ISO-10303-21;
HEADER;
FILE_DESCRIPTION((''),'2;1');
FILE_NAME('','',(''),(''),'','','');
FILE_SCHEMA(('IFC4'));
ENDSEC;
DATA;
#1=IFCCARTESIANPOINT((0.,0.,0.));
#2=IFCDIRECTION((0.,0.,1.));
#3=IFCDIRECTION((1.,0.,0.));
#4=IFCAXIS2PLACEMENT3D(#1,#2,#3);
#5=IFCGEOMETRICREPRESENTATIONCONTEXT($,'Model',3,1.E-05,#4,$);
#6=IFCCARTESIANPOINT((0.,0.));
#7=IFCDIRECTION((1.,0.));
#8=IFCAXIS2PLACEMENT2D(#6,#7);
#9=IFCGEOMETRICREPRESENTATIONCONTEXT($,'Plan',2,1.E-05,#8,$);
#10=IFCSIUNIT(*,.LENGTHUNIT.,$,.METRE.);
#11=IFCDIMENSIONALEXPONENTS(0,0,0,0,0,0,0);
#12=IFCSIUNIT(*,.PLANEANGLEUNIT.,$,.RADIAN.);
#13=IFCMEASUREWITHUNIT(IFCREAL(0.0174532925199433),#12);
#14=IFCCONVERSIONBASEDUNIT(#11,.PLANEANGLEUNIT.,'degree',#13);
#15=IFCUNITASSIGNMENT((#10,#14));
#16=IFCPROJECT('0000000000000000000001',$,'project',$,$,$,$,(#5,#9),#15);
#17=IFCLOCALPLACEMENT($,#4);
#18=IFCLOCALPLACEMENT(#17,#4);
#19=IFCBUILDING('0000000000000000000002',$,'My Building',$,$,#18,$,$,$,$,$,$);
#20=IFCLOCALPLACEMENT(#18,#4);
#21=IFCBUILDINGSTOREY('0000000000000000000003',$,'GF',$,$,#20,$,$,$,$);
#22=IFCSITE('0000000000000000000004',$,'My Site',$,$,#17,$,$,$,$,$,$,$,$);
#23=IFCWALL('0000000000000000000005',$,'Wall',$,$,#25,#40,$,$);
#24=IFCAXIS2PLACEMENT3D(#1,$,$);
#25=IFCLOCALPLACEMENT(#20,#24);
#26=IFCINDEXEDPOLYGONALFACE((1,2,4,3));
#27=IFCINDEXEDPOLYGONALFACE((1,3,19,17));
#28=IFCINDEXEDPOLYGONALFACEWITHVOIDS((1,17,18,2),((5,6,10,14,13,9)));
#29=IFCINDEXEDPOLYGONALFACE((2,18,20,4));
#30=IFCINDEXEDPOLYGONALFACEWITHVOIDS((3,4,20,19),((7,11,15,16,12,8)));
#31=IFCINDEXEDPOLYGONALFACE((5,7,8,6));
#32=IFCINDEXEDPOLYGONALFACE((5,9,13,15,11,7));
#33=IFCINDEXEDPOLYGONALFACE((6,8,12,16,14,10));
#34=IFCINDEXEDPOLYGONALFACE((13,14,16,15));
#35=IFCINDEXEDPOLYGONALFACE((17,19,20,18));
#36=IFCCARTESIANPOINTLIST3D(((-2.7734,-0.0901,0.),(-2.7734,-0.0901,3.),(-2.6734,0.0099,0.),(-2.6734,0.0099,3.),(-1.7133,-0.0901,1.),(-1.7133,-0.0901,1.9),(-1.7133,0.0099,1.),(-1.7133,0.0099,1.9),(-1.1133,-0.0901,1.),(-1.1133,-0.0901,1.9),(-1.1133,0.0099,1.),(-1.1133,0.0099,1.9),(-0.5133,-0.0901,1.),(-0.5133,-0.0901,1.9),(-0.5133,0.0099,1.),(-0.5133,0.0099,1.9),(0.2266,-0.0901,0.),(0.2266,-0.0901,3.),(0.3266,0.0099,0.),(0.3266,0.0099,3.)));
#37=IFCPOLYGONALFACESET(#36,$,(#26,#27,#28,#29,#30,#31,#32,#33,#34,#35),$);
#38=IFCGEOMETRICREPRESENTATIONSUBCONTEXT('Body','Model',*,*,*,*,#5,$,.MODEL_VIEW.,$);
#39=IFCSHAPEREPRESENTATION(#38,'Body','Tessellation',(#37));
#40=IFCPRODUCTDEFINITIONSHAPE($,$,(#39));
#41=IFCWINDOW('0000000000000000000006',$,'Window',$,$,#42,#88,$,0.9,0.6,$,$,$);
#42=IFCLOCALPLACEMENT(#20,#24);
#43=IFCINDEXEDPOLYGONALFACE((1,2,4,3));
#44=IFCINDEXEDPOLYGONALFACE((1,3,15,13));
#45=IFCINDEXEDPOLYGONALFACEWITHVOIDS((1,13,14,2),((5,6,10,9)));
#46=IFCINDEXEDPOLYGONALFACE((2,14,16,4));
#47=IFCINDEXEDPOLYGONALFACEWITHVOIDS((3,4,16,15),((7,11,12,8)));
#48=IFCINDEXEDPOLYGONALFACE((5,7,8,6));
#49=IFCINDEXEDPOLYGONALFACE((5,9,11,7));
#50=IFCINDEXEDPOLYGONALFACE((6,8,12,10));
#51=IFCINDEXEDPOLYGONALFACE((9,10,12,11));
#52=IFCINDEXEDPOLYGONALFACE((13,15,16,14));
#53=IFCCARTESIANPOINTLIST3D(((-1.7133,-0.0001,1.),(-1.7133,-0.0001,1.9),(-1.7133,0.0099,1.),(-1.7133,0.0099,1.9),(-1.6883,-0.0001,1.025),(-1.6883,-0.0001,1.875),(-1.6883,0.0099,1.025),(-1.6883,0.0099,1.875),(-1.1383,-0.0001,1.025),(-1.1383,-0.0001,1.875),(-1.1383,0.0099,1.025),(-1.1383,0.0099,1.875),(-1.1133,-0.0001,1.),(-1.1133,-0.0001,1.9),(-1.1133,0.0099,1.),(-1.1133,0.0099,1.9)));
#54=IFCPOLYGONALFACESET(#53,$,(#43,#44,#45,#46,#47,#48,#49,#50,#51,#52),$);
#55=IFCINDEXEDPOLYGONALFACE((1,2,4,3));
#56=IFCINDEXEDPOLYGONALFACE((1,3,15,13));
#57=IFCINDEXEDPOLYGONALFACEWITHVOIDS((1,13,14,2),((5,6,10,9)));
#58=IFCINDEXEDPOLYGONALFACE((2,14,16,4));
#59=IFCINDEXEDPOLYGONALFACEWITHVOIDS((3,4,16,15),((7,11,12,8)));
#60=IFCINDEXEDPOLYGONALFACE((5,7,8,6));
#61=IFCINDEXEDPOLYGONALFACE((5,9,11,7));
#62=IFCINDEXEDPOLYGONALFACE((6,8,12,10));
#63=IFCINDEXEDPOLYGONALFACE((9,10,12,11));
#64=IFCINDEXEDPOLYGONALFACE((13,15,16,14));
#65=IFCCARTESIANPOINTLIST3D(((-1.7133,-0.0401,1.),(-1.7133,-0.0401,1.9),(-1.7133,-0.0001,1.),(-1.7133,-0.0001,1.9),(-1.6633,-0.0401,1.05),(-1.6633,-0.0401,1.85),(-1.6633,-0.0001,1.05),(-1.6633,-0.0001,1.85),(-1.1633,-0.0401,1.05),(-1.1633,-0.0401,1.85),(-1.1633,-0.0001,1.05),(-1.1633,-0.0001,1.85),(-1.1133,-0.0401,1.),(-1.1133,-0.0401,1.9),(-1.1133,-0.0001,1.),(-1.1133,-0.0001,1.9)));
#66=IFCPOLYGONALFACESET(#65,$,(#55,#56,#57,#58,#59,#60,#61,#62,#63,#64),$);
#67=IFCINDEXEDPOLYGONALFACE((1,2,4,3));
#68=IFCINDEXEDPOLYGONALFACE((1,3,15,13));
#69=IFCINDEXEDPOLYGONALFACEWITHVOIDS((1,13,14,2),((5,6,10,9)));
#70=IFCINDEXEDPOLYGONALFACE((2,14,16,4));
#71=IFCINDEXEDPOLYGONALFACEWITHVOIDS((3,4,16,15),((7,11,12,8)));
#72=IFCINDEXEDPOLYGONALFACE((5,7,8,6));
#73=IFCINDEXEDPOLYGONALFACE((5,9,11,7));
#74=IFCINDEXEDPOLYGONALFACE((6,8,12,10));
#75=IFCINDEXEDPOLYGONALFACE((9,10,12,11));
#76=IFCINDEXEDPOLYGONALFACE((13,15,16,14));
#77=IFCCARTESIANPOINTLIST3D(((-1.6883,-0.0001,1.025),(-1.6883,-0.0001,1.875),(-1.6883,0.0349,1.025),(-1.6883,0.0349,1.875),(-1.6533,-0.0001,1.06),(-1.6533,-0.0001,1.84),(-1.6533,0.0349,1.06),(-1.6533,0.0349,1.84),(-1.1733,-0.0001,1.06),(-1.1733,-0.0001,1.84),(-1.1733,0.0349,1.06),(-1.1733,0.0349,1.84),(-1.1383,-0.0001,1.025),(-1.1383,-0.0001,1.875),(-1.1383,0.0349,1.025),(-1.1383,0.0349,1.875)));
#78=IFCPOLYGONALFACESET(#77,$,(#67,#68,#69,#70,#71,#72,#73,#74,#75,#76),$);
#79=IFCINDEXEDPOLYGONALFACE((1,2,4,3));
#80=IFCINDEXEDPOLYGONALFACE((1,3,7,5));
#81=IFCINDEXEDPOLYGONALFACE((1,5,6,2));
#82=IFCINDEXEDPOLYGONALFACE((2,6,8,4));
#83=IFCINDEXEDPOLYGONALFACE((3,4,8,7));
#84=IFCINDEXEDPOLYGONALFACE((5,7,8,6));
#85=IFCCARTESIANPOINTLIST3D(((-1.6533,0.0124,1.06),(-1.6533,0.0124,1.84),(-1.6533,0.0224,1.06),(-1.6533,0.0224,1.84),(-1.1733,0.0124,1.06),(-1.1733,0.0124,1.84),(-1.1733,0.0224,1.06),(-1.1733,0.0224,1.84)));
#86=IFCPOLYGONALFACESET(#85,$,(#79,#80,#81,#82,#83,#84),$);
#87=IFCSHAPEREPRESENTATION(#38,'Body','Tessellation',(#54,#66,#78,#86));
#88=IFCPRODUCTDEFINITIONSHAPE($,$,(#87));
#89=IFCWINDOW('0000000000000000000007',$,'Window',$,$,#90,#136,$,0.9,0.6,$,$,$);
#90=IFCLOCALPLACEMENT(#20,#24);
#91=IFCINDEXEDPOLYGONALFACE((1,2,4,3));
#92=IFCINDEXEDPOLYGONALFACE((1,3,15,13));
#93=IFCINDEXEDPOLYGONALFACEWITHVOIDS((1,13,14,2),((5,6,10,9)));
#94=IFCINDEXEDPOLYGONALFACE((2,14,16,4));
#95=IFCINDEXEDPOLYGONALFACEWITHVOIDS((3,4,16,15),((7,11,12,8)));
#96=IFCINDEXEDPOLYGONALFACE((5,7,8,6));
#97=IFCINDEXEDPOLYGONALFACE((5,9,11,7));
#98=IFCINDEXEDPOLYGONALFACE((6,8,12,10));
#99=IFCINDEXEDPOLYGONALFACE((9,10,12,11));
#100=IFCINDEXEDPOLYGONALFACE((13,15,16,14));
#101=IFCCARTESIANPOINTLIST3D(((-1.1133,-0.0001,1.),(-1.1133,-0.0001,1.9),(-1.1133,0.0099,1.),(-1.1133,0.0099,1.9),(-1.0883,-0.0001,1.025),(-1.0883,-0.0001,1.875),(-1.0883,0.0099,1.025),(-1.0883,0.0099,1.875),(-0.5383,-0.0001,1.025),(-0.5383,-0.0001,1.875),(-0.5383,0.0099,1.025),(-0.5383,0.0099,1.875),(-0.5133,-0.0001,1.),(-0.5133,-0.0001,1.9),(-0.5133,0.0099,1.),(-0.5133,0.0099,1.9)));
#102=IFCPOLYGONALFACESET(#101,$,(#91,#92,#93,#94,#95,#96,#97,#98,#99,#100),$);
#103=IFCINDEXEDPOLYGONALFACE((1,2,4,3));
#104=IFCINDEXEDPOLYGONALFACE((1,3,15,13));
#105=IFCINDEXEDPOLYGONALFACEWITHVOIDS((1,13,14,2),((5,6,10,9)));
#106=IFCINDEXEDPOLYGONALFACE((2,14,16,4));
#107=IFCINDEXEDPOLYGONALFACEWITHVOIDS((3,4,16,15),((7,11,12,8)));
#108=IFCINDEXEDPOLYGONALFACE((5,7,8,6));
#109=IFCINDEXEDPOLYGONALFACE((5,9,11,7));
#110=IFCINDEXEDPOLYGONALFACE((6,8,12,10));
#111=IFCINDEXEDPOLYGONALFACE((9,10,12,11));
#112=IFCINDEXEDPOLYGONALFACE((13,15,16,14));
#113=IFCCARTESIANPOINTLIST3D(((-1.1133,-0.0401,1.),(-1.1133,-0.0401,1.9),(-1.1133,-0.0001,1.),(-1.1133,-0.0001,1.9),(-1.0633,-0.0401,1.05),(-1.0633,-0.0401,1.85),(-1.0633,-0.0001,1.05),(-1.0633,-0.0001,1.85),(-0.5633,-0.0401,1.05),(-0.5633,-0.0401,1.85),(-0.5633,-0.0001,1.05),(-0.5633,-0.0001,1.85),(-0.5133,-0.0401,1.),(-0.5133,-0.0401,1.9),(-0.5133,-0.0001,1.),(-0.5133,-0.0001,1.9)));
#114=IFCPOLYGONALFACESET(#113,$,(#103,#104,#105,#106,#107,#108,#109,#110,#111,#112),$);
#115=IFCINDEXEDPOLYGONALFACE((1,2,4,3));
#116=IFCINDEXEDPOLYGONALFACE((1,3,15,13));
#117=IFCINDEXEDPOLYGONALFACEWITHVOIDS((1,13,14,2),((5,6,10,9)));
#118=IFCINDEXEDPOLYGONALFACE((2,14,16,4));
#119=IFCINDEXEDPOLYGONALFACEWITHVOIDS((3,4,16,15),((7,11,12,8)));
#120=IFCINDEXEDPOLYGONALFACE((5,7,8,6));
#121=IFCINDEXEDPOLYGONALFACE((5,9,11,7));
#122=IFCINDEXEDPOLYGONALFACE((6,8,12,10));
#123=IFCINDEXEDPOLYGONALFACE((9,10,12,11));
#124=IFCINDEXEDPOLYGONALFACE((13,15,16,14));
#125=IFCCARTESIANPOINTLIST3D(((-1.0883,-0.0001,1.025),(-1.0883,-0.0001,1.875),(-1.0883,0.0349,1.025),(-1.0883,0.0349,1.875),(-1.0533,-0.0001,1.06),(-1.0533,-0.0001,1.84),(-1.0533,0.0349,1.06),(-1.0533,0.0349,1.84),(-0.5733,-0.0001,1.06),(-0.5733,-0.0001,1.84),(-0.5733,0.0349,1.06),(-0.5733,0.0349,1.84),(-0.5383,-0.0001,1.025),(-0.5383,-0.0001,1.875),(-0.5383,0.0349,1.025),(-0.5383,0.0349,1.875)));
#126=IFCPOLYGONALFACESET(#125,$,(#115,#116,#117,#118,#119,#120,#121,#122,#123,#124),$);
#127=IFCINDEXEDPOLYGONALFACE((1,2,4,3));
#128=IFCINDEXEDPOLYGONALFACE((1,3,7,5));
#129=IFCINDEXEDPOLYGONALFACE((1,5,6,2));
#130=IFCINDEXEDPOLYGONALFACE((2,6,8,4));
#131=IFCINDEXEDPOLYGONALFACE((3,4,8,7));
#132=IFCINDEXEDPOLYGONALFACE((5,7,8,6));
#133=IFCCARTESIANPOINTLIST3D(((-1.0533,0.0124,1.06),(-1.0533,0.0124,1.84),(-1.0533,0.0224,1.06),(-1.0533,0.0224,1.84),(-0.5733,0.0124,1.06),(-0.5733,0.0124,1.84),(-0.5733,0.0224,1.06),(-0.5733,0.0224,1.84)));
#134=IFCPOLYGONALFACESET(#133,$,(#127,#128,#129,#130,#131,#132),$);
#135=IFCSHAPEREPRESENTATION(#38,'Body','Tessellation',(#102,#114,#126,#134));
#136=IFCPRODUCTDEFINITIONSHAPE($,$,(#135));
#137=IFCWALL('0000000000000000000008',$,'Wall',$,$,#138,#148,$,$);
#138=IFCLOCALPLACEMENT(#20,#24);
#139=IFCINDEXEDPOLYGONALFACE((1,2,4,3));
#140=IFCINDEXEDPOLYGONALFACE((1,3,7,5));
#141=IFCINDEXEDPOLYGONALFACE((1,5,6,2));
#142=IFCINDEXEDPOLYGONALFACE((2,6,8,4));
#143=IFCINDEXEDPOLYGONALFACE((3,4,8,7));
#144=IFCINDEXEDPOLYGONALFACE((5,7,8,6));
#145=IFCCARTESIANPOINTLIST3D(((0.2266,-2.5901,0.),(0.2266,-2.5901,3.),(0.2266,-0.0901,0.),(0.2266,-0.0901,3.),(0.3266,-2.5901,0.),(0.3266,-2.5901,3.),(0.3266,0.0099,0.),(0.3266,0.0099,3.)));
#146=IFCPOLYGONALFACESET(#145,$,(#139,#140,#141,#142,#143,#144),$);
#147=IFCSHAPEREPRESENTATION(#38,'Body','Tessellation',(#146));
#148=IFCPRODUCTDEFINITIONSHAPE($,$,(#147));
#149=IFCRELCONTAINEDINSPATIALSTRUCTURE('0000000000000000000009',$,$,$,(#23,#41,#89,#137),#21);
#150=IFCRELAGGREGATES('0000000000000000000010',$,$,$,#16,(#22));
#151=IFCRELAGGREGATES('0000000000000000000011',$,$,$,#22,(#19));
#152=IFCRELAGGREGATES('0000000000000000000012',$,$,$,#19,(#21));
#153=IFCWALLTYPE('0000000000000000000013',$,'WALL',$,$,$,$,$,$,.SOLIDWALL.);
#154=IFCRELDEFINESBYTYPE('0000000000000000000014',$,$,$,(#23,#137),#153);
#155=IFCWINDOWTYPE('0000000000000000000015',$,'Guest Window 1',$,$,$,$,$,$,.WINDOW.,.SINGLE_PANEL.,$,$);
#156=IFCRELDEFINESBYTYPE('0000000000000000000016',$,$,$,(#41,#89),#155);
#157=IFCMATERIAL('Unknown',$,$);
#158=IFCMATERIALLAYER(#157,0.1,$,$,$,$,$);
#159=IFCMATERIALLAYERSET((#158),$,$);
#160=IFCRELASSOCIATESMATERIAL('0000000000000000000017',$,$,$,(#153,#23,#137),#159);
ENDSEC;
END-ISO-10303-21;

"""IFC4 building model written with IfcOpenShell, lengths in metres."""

from ifc_helpers import new_model, entity, si_unit, converted_unit, frame, origin_with_axes, origin_2d_with_axis, place, context, subcontext, project, spatial, line, indexed_curve, outline, extrude, shape, source, transform, mapped, material, layer, layer_set, layer_usage, type_object, type_shapes, element, fill, save


model = new_model("IFC4")

# Units and contexts
model_context = context("Model", 3, precision=1e-05, world=origin_with_axes())
plan_context = context("Plan", 2, precision=1e-05, world=origin_2d_with_axis())
body_context_1 = subcontext(model_context, "Body", "Model", "MODEL_VIEW")
body_context_2 = subcontext(plan_context, "Body", "Plan", "PLAN_VIEW")
ifc_project = project(units=[si_unit("LENGTHUNIT", "METRE"), converted_unit("PLANEANGLEUNIT", "degree", entity("IfcReal", 0.0174532925199433), si_unit("PLANEANGLEUNIT", "RADIAN"), dimensions=[0, 0, 0, 0, 0, 0, 0])], contexts=[model_context, plan_context])

# Site, building, storey
site_placement = place(None, origin_with_axes())
site = spatial("IfcSite", under=ifc_project, at=site_placement, Name="My Site")
building_placement = place(site_placement, origin_with_axes())
building = spatial("IfcBuilding", under=site, at=building_placement, Name="My Building")
storey_placement = place(building_placement, origin_with_axes())
storey = spatial("IfcBuildingStorey", under=building, at=storey_placement, Name="GF")

# Shared definitions
ifc_material_1 = material(Name="Unknown")

# Shared definitions
ifc_layer_1 = layer(ifc_material_1, 0.1)
ifc_layer_set_1 = layer_set([ifc_layer_1])
wall_type = type_object("IfcWallType", Name="WALL", PredefinedType="SOLIDWALL", material=ifc_layer_set_1)

# Wall, openings, windows
ifc_layer_usage_1 = layer_usage(ifc_layer_set_1, "AXIS2", "POSITIVE", 0.0)
wall_1_placement = place(storey_placement, frame((-2.7734, -0.0901, 0.0), z_axis=(0.0, 0.0, 1.0), x_axis=(1.0, 0.0, 0.0)))
wall_1 = element("IfcWall", 1, at=wall_1_placement, inside=storey, type_object=wall_type, material=ifc_layer_usage_1, Name="Wall", context=body_context_1, shape_type="SweptSolid", body=[
    extrude(outline(indexed_curve([(0.0, 0.0), (0.1, 0.1), (3.1, 0.1), (3.0, 0.0)], segments=[line(1, 2, 3, 4, 1)])), origin_with_axes(), (0.0, 0.0, 1.0), 3.0),
])
shared_shape_1 = source(origin_with_axes(), body_context_1, "Body", "SweptSolid", [
    extrude(outline(indexed_curve([(0.0, 0.0), (0.6, 0.0), (0.6, 0.9), (0.0, 0.9)], segments=[line(1, 2, 3, 4, 1)])), frame((0.0, -0.6, 0.0), z_axis=(0.0, -1.0, 0.0), x_axis=(1.0, 0.0, 0.0)), (0.0, 0.0, -1.0), 1.2),
])
opening_1_placement = place(wall_1_placement, frame((1.0601, 0.0, 1.0), z_axis=(0.0, 0.0, 1.0), x_axis=(1.0, 0.0, 0.0)))
opening_1 = element("IfcOpeningElement", 2, at=opening_1_placement, cuts=wall_1, PredefinedType="OPENING", context=body_context_1, shape_type="MappedRepresentation", body=[
    mapped(shared_shape_1, transform((0.0, 0.0, 0.0), x_axis=(1.0, 0.0, 0.0), y_axis=(0.0, 1.0, 0.0), z_axis=(0.0, 0.0, 1.0), scale=1.0)),
])
opening_2_placement = place(wall_1_placement, frame((1.6601, 0.0, 1.0), z_axis=(0.0, 0.0, 1.0), x_axis=(1.0, 0.0, 0.0)))
opening_2 = element("IfcOpeningElement", 3, at=opening_2_placement, cuts=wall_1, PredefinedType="OPENING", context=body_context_1, shape_type="MappedRepresentation", body=[
    mapped(shared_shape_1, transform((0.0, 0.0, 0.0), x_axis=(1.0, 0.0, 0.0), y_axis=(0.0, 1.0, 0.0), z_axis=(0.0, 0.0, 1.0), scale=1.0)),
])
window_type_1 = type_object("IfcWindowType", Name="Guest Window 1", PartitioningType="SINGLE_PANEL", PredefinedType="WINDOW")
shared_shape_2 = source(origin_with_axes(), body_context_1, "Body", "SweptSolid", [
    extrude(outline(indexed_curve([(0.0, 0.0), (0.6, 0.0), (0.6, 0.9), (0.0, 0.9)], segments=[line(1, 2, 3, 4, 1)]), holes=[indexed_curve([(0.025, 0.025), (0.575, 0.025), (0.575, 0.875), (0.025, 0.875)], segments=[line(1, 2, 3, 4, 1)])]), frame((0.0, 0.09, 0.0), z_axis=(0.0, -1.0, 0.0), x_axis=(1.0, 0.0, 0.0)), (0.0, 0.0, -1.0), 0.01),
    extrude(outline(indexed_curve([(0.0, 0.0), (0.6, 0.0), (0.6, 0.9), (0.0, 0.9)], segments=[line(1, 2, 3, 4, 1)]), holes=[indexed_curve([(0.05, 0.05), (0.55, 0.05), (0.55, 0.85), (0.05, 0.85)], segments=[line(1, 2, 3, 4, 1)])]), frame((0.0, 0.05, 0.0), z_axis=(0.0, -1.0, 0.0), x_axis=(1.0, 0.0, 0.0)), (0.0, 0.0, -1.0), 0.04),
    extrude(outline(indexed_curve([(0.0, 0.0), (0.55, 0.0), (0.55, 0.85), (0.0, 0.85)], segments=[line(1, 2, 3, 4, 1)]), holes=[indexed_curve([(0.035, 0.035), (0.515, 0.035), (0.515, 0.815), (0.035, 0.815)], segments=[line(1, 2, 3, 4, 1)])]), frame((0.025, 0.09, 0.025), z_axis=(0.0, -1.0, 0.0), x_axis=(1.0, 0.0, 0.0)), (0.0, 0.0, -1.0), 0.035),
    extrude(outline(indexed_curve([(0.035, 0.035), (0.515, 0.035), (0.515, 0.815), (0.035, 0.815)], segments=[line(1, 2, 3, 4, 1)])), frame((0.025, 0.1025, 0.025), z_axis=(0.0, -1.0, 0.0), x_axis=(1.0, 0.0, 0.0)), (0.0, 0.0, -1.0), 0.01),
])
shared_shape_3 = source(origin_with_axes(), body_context_2, "Body", "Curve2D", [
    entity("IfcIndexedPolyCurve", entity("IfcCartesianPointList2D", [[0.05, 0.05], [0.55, 0.05]])),
    entity("IfcIndexedPolyCurve", entity("IfcCartesianPointList2D", [[0.0, 0.1], [0.025, 0.1], [0.025, 0.09], [0.05, 0.09], [0.05, 0.05], [0.0, 0.05]]), [entity("IfcLineIndex", [1, 2, 3, 4, 5, 6, 1])]),
    entity("IfcIndexedPolyCurve", entity("IfcCartesianPointList2D", [[0.6, 0.1], [0.575, 0.1], [0.575, 0.09], [0.55, 0.09], [0.55, 0.05], [0.6, 0.05]]), [entity("IfcLineIndex", [1, 2, 3, 4, 5, 6, 1])]),
    entity("IfcIndexedPolyCurve", entity("IfcCartesianPointList2D", [[0.025, 0.09], [0.06, 0.09], [0.06, 0.125], [0.025, 0.125]]), [entity("IfcLineIndex", [1, 2, 3, 4, 1])]),
    entity("IfcIndexedPolyCurve", entity("IfcCartesianPointList2D", [[0.575, 0.09], [0.54, 0.09], [0.54, 0.125], [0.575, 0.125]]), [entity("IfcLineIndex", [1, 2, 3, 4, 1])]),
    entity("IfcIndexedPolyCurve", entity("IfcCartesianPointList2D", [[0.06, 0.09], [0.54, 0.09]])),
    entity("IfcIndexedPolyCurve", entity("IfcCartesianPointList2D", [[0.06, 0.125], [0.54, 0.125]])),
    entity("IfcIndexedPolyCurve", entity("IfcCartesianPointList2D", [[0.06, 0.1075], [0.54, 0.1075]])),
])
type_shapes(window_type_1, [shared_shape_2, shared_shape_3])
window_1_placement = place(opening_1_placement, origin_with_axes())
window_1 = element("IfcWindow", 4, at=window_1_placement, inside=storey, type_object=window_type_1, Name="Window", OverallHeight=0.9, OverallWidth=0.6, shapes=[
    shape(body_context_1, "Body", "MappedRepresentation", [mapped(shared_shape_2, transform((0.0, 0.0, 0.0), x_axis=(1.0, 0.0, 0.0), y_axis=(0.0, 1.0, 0.0), z_axis=(0.0, 0.0, 1.0), scale=1.0))]),
    shape(body_context_2, "Body", "MappedRepresentation", [mapped(shared_shape_3, transform((0.0, 0.0, 0.0), x_axis=(1.0, 0.0, 0.0), y_axis=(0.0, 1.0, 0.0), z_axis=(0.0, 0.0, 1.0), scale=1.0))]),
])
fill(opening_1, window_1)
window_2_placement = place(opening_2_placement, origin_with_axes())
window_2 = element("IfcWindow", 5, at=window_2_placement, inside=storey, type_object=window_type_1, Name="Window", OverallHeight=0.9, OverallWidth=0.6, shapes=[
    shape(body_context_1, "Body", "MappedRepresentation", [mapped(shared_shape_2, transform((0.0, 0.0, 0.0), x_axis=(1.0, 0.0, 0.0), y_axis=(0.0, 1.0, 0.0), z_axis=(0.0, 0.0, 1.0), scale=1.0))]),
    shape(body_context_2, "Body", "MappedRepresentation", [mapped(shared_shape_3, transform((0.0, 0.0, 0.0), x_axis=(1.0, 0.0, 0.0), y_axis=(0.0, 1.0, 0.0), z_axis=(0.0, 0.0, 1.0), scale=1.0))]),
])
fill(opening_2, window_2)

# Wall
ifc_layer_usage_2 = layer_usage(ifc_layer_set_1, "AXIS2", "POSITIVE", 0.0)
wall_2_placement = place(storey_placement, frame((0.2266, -0.0901, 0.0), z_axis=(0.0, 0.0, 1.0), x_axis=(0.0, -1.0, 0.0)))
element("IfcWall", 6, at=wall_2_placement, inside=storey, type_object=wall_type, material=ifc_layer_usage_2, Name="Wall", context=body_context_1, shape_type="SweptSolid", body=[
    extrude(outline(indexed_curve([(0.0, 0.0), (-0.1, 0.1), (2.5, 0.1), (2.5, 0.0)], segments=[line(1, 2, 3, 4, 1)])), origin_with_axes(), (0.0, 0.0, 1.0), 3.0),
])

save(model, "model.ifc")
